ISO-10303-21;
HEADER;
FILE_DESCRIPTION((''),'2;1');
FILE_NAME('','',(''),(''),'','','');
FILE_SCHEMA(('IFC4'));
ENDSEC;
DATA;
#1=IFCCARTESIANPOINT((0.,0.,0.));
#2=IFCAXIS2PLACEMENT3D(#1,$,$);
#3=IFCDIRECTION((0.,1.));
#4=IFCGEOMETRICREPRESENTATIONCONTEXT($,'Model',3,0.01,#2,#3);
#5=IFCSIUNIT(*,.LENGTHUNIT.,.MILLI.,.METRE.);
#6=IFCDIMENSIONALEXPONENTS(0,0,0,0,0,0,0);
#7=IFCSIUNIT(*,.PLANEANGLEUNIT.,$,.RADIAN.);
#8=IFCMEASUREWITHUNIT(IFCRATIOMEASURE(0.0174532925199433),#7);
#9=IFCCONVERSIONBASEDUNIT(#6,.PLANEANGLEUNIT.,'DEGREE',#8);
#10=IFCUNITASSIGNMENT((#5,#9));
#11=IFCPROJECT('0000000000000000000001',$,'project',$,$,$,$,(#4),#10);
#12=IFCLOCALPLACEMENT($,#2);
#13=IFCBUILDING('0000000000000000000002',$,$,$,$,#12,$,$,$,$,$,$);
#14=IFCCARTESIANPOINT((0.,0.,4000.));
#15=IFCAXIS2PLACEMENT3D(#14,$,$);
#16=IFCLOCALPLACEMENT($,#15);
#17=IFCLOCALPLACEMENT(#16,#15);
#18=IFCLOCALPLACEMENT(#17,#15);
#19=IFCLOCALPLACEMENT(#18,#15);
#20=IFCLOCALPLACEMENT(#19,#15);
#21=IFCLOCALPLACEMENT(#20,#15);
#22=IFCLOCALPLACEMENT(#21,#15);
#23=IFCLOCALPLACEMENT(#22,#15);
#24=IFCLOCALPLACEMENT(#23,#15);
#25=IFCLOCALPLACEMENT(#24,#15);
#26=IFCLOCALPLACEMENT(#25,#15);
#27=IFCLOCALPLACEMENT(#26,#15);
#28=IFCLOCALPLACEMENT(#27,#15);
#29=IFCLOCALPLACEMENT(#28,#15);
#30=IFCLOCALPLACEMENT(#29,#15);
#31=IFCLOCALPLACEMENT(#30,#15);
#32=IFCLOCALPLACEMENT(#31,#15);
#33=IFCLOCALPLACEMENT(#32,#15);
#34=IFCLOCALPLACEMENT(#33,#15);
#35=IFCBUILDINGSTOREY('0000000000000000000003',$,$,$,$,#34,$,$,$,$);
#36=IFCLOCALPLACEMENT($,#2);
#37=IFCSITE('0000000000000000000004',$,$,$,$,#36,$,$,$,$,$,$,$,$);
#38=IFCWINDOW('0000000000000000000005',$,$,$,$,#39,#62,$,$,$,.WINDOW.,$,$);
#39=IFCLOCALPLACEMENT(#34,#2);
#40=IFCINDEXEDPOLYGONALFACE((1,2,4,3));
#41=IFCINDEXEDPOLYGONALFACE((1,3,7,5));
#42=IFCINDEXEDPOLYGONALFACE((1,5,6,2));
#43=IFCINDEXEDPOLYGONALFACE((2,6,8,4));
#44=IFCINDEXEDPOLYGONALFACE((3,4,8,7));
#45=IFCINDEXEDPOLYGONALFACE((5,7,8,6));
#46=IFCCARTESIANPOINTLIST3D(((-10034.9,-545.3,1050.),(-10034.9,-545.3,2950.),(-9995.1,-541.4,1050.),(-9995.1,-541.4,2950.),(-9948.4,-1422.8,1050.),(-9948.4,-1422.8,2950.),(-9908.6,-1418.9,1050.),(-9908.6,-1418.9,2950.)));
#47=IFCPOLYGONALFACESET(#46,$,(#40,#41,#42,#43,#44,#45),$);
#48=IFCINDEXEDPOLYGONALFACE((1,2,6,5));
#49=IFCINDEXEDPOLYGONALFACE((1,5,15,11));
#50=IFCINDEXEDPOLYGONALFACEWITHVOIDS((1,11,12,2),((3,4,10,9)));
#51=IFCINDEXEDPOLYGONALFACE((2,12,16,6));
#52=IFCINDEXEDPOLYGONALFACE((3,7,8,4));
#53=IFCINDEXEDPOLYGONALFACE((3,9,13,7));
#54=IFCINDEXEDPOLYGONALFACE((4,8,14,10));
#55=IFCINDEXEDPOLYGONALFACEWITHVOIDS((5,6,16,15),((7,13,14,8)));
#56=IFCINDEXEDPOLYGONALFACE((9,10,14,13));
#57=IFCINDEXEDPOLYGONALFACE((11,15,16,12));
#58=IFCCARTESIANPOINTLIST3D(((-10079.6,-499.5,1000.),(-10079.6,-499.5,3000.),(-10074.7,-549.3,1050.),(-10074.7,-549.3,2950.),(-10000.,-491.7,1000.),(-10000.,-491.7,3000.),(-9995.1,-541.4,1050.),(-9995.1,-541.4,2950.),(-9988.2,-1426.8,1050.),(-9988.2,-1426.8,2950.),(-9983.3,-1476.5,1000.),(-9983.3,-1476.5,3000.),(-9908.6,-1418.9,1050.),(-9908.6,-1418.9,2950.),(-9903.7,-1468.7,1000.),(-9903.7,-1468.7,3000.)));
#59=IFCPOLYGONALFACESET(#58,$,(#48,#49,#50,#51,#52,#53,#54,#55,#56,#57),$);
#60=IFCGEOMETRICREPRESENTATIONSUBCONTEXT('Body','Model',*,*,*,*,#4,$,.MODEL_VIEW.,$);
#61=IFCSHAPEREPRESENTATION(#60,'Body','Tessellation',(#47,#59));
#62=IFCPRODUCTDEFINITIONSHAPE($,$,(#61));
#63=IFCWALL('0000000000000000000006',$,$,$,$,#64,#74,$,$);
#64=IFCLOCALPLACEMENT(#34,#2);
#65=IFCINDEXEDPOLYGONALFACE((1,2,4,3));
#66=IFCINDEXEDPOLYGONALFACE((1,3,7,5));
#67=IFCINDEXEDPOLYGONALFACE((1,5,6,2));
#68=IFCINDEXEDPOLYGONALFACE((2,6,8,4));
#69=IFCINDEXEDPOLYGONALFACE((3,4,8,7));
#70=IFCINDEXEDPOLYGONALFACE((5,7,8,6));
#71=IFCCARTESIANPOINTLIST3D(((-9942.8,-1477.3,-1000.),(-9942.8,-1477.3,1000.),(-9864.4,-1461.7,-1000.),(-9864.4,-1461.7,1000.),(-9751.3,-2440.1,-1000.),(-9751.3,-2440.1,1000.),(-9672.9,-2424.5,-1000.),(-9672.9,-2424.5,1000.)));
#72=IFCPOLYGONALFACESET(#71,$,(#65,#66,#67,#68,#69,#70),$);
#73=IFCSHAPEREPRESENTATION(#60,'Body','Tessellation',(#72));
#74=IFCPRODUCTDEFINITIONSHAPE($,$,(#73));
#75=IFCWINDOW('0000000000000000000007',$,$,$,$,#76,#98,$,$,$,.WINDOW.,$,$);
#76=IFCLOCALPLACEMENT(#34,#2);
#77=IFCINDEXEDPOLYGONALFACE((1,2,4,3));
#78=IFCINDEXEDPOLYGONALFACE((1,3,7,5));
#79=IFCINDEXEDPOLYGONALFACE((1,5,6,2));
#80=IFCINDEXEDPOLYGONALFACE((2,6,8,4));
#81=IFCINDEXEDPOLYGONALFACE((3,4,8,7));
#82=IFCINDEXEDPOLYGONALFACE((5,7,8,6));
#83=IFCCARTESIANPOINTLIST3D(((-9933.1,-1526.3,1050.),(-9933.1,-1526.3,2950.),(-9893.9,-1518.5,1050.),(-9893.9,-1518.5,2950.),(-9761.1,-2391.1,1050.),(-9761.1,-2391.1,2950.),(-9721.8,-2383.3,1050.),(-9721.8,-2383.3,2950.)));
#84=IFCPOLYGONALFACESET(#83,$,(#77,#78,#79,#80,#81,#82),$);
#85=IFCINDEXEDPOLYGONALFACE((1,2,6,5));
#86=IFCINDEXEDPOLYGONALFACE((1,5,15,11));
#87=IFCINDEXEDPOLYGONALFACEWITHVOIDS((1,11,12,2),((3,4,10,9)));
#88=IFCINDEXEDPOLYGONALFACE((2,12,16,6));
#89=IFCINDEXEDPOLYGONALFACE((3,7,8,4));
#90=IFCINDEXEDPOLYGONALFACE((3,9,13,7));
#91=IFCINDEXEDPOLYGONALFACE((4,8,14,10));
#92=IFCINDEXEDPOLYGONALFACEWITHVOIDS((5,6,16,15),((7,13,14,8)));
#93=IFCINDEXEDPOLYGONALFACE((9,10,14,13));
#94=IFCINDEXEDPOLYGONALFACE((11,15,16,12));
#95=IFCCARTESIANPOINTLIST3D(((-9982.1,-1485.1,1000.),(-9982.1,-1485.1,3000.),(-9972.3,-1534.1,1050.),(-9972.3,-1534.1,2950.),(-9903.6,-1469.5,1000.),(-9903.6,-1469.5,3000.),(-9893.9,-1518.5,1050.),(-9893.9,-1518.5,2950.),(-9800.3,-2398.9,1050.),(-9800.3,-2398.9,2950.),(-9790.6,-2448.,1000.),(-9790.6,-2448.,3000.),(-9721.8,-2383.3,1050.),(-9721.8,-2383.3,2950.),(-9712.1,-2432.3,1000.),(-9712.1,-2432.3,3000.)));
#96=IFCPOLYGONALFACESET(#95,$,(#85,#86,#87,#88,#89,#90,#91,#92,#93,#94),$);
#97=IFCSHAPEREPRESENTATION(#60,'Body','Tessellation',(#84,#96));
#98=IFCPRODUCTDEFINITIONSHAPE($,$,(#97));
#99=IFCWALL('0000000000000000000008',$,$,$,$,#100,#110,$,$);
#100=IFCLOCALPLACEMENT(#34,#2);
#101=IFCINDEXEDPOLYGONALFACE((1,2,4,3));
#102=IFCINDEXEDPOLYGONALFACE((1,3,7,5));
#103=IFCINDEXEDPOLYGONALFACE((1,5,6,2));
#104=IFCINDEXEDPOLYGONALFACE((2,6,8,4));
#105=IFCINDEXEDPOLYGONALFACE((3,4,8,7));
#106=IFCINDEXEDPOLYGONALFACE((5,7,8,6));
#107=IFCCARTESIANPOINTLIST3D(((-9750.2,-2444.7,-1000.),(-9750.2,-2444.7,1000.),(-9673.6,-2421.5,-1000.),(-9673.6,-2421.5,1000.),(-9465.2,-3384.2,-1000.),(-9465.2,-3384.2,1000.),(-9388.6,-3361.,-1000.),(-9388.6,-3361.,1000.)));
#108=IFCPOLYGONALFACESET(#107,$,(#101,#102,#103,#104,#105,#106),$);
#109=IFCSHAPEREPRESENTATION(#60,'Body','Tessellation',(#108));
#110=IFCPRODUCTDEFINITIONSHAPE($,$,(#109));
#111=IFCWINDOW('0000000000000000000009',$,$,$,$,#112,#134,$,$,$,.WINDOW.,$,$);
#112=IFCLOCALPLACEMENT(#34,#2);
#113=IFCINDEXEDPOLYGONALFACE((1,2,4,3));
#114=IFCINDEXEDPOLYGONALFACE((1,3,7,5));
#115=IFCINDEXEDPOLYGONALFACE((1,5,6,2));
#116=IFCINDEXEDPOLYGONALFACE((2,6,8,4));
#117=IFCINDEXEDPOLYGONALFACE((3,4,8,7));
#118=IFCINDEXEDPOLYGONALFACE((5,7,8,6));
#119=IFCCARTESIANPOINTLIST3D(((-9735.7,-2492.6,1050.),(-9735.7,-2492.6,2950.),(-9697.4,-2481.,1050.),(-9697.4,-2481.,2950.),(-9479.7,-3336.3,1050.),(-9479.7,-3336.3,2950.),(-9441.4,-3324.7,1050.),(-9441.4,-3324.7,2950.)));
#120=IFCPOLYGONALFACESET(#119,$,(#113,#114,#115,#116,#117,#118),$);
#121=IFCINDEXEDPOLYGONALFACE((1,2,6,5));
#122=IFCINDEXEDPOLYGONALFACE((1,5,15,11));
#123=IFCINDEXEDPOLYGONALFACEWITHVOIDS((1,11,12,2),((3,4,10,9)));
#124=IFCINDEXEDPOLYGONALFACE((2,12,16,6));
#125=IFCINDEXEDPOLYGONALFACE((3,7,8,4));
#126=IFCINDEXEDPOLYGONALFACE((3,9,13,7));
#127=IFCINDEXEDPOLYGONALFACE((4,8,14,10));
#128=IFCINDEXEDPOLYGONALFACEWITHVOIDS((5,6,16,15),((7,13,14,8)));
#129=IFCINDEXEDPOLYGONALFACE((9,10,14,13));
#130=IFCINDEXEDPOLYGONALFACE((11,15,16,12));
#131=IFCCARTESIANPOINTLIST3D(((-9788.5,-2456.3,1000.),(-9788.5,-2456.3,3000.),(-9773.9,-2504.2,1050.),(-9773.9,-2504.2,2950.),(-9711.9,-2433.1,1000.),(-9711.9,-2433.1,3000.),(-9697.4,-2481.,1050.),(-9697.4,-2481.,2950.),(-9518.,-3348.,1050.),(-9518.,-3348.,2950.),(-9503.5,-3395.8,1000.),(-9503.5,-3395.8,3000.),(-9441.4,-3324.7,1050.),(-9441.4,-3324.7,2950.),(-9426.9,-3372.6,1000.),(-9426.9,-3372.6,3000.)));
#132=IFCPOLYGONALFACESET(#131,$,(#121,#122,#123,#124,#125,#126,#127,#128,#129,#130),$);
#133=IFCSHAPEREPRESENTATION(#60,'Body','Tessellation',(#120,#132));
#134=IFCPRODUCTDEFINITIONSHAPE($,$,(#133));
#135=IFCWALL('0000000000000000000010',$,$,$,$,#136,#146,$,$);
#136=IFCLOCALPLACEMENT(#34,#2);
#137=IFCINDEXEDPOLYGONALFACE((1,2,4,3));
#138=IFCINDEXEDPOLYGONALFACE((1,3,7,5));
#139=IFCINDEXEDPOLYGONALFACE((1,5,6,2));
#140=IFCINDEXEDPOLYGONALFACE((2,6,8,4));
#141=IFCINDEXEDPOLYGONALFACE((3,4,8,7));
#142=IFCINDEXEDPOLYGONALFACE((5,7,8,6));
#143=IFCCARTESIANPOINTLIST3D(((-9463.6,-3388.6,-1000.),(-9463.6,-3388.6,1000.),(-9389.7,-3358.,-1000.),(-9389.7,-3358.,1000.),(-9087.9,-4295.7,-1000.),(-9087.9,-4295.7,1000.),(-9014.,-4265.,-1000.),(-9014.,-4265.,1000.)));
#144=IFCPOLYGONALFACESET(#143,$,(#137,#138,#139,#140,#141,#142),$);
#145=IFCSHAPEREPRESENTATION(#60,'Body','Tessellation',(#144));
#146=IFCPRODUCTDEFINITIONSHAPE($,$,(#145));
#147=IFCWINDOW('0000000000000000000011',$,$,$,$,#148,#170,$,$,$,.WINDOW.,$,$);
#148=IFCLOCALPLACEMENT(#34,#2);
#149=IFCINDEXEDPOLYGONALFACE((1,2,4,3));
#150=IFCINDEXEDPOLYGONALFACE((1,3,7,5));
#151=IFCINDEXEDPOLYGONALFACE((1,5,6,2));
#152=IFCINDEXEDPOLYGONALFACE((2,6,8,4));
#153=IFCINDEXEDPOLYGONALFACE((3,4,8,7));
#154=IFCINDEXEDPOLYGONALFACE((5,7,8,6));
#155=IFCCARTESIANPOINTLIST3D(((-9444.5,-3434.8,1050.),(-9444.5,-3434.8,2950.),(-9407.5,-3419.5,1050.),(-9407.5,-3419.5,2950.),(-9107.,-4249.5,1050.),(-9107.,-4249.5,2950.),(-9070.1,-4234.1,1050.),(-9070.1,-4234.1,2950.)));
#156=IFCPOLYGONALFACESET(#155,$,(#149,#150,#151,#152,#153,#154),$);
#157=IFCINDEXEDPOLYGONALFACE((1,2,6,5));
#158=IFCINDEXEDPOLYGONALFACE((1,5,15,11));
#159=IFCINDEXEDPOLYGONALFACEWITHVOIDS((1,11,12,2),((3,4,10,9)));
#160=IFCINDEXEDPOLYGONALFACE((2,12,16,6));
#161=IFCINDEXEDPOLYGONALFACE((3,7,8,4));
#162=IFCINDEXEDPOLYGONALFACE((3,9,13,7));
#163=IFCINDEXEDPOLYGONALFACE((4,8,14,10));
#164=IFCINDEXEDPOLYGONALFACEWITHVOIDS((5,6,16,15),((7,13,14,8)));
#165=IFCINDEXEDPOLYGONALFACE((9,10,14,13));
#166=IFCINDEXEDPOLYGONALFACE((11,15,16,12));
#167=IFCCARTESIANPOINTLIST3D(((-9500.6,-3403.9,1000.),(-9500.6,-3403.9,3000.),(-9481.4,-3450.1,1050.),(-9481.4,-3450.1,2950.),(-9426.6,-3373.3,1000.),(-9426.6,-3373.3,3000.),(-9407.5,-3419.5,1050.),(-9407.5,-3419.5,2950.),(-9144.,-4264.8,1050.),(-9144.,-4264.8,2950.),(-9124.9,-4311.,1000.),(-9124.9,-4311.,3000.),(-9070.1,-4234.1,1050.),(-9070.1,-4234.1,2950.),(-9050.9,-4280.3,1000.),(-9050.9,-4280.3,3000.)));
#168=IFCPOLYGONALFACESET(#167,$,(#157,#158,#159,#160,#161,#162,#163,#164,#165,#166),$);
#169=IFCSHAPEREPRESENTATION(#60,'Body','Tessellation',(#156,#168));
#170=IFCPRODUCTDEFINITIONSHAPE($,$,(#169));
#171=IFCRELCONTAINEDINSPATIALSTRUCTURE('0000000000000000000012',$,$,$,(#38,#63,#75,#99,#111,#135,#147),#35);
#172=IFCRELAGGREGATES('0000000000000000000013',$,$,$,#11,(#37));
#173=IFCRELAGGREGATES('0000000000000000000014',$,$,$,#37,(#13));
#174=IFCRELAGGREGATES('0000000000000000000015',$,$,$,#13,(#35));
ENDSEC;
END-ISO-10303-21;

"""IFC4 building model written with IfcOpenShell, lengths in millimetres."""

from ifc_helpers import new_model, entity, si_unit, converted_unit, direction, frame, origin, origin_2d, place, context, subcontext, project, spatial, rectangle, extrude, element, save


model = new_model("IFC4")

# Units and contexts
model_context = context("Model", 3, precision=0.01, world=origin(), true_north=direction((0.0, 1.0)))
body_context = subcontext(model_context, "Body", "Model", "MODEL_VIEW")
ifc_project = project(units=[si_unit("LENGTHUNIT", "METRE", prefix="MILLI"), converted_unit("PLANEANGLEUNIT", "DEGREE", entity("IfcRatioMeasure", 0.0174532925199433), si_unit("PLANEANGLEUNIT", "RADIAN"), dimensions=[0, 0, 0, 0, 0, 0, 0])], contexts=[model_context])

# Site, building, storey
site_placement = place(None, origin())
site = spatial("IfcSite", under=ifc_project, at=site_placement)
building_placement = place(None, origin())
building = spatial("IfcBuilding", under=site, at=building_placement)
placement_1 = place(None, frame((0.0, 0.0, 4000.0)))
placement_2 = place(placement_1, frame((0.0, 0.0, 4000.0)))
placement_3 = place(placement_2, frame((0.0, 0.0, 4000.0)))
placement_4 = place(placement_3, frame((0.0, 0.0, 4000.0)))
placement_5 = place(placement_4, frame((0.0, 0.0, 4000.0)))
placement_6 = place(placement_5, frame((0.0, 0.0, 4000.0)))
placement_7 = place(placement_6, frame((0.0, 0.0, 4000.0)))
placement_8 = place(placement_7, frame((0.0, 0.0, 4000.0)))
placement_9 = place(placement_8, frame((0.0, 0.0, 4000.0)))
placement_10 = place(placement_9, frame((0.0, 0.0, 4000.0)))
placement_11 = place(placement_10, frame((0.0, 0.0, 4000.0)))
placement_12 = place(placement_11, frame((0.0, 0.0, 4000.0)))
placement_13 = place(placement_12, frame((0.0, 0.0, 4000.0)))
placement_14 = place(placement_13, frame((0.0, 0.0, 4000.0)))
placement_15 = place(placement_14, frame((0.0, 0.0, 4000.0)))
placement_16 = place(placement_15, frame((0.0, 0.0, 4000.0)))
placement_17 = place(placement_16, frame((0.0, 0.0, 4000.0)))
placement_18 = place(placement_17, frame((0.0, 0.0, 4000.0)))
storey_placement = place(placement_18, frame((0.0, 0.0, 4000.0)))
storey = spatial("IfcBuildingStorey", under=building, at=storey_placement)

# Shared definitions
cartesian_point_1 = entity("IfcCartesianPoint", [-440.9, -950.0])
shared_polyline = entity("IfcPolyline", [cartesian_point_1, entity("IfcCartesianPoint", [-440.9, 950.0]), entity("IfcCartesianPoint", [-440.9, 950.0]), entity("IfcCartesianPoint", [440.9, 950.0]), entity("IfcCartesianPoint", [440.9, 950.0]), entity("IfcCartesianPoint", [440.9, -950.0]), entity("IfcCartesianPoint", [440.9, -950.0]), entity("IfcCartesianPoint", [-440.9, -950.0]), cartesian_point_1])

# Window
window_1_placement = place(storey_placement, frame((-9951.8, -980.2, 2000.0), z_axis=(0.0, 0.0, 1.0), x_axis=(980.170299, -9951.847376, 0.0)))
cartesian_point_2 = entity("IfcCartesianPoint", [-490.9, -1000.0])
element("IfcWindow", 1, at=window_1_placement, inside=storey, PredefinedType="WINDOW", context=body_context, shape_type="SweptSolid", body=[
    entity("IfcExtrudedAreaSolid", entity("IfcArbitraryClosedProfileDef", "AREA", None, shared_polyline), entity("IfcAxis2Placement3D", entity("IfcCartesianPoint", [0.0, 0.0, 0.0]), entity("IfcDirection", [0.0, -1.0, 0.0]), entity("IfcDirection", [1.0, 0.0, 0.0])), entity("IfcDirection", [0.0, 0.0, 1.0]), 40.0),
    entity("IfcExtrudedAreaSolid", entity("IfcArbitraryProfileDefWithVoids", "AREA", None, entity("IfcPolyline", [cartesian_point_2, entity("IfcCartesianPoint", [-490.9, 1000.0]), entity("IfcCartesianPoint", [-490.9, 1000.0]), entity("IfcCartesianPoint", [490.9, 1000.0]), entity("IfcCartesianPoint", [490.9, 1000.0]), entity("IfcCartesianPoint", [490.9, -1000.0]), entity("IfcCartesianPoint", [490.9, -1000.0]), entity("IfcCartesianPoint", [-490.9, -1000.0]), cartesian_point_2]), [shared_polyline]), entity("IfcAxis2Placement3D", entity("IfcCartesianPoint", [0.0, 0.0, 0.0]), entity("IfcDirection", [0.0, -1.0, 0.0]), entity("IfcDirection", [1.0, 0.0, 0.0])), entity("IfcDirection", [0.0, 0.0, 1.0]), 80.0),
])

# Wall
wall_1_placement = place(storey_placement, frame((-9807.9, -1950.9, -1000.0), z_axis=(0.0, 0.0, 1.0), x_axis=(1950.902524, -9807.852943, 0.0)))
element("IfcWall", 2, at=wall_1_placement, inside=storey, context=body_context, shape_type="SweptSolid", body=[
    extrude(rectangle(XDim=981.7, YDim=80.0, at=origin_2d()), origin(), (0.0, 0.0, 1.0), 2000.0),
])

# Window
window_2_placement = place(storey_placement, frame((-9807.9, -1950.9, 2000.0), z_axis=(0.0, 0.0, 1.0), x_axis=(1950.902524, -9807.852943, 0.0)))
cartesian_point_3 = entity("IfcCartesianPoint", [-490.9, -1000.0])
element("IfcWindow", 3, at=window_2_placement, inside=storey, PredefinedType="WINDOW", context=body_context, shape_type="SweptSolid", body=[
    entity("IfcExtrudedAreaSolid", entity("IfcArbitraryClosedProfileDef", "AREA", None, shared_polyline), entity("IfcAxis2Placement3D", entity("IfcCartesianPoint", [0.0, 0.0, 0.0]), entity("IfcDirection", [0.0, -1.0, 0.0]), entity("IfcDirection", [1.0, 0.0, 0.0])), entity("IfcDirection", [0.0, 0.0, 1.0]), 40.0),
    entity("IfcExtrudedAreaSolid", entity("IfcArbitraryProfileDefWithVoids", "AREA", None, entity("IfcPolyline", [cartesian_point_3, entity("IfcCartesianPoint", [-490.9, 1000.0]), entity("IfcCartesianPoint", [-490.9, 1000.0]), entity("IfcCartesianPoint", [490.9, 1000.0]), entity("IfcCartesianPoint", [490.9, 1000.0]), entity("IfcCartesianPoint", [490.9, -1000.0]), entity("IfcCartesianPoint", [490.9, -1000.0]), entity("IfcCartesianPoint", [-490.9, -1000.0]), cartesian_point_3]), [shared_polyline]), entity("IfcAxis2Placement3D", entity("IfcCartesianPoint", [0.0, 0.0, 0.0]), entity("IfcDirection", [0.0, -1.0, 0.0]), entity("IfcDirection", [1.0, 0.0, 0.0])), entity("IfcDirection", [0.0, 0.0, 1.0]), 80.0),
])

# Wall
wall_2_placement = place(storey_placement, frame((-9569.4, -2902.8, -1000.0), z_axis=(0.0, 0.0, 1.0), x_axis=(2902.846475, -9569.403447, 0.0)))
element("IfcWall", 4, at=wall_2_placement, inside=storey, context=body_context, shape_type="SweptSolid", body=[
    extrude(rectangle(XDim=981.7, YDim=80.0, at=origin_2d()), origin(), (0.0, 0.0, 1.0), 2000.0),
])

# Window
window_3_placement = place(storey_placement, frame((-9569.4, -2902.8, 2000.0), z_axis=(0.0, 0.0, 1.0), x_axis=(2902.846475, -9569.403447, 0.0)))
cartesian_point_4 = entity("IfcCartesianPoint", [-490.9, -1000.0])
element("IfcWindow", 5, at=window_3_placement, inside=storey, PredefinedType="WINDOW", context=body_context, shape_type="SweptSolid", body=[
    entity("IfcExtrudedAreaSolid", entity("IfcArbitraryClosedProfileDef", "AREA", None, shared_polyline), entity("IfcAxis2Placement3D", entity("IfcCartesianPoint", [0.0, 0.0, 0.0]), entity("IfcDirection", [0.0, -1.0, 0.0]), entity("IfcDirection", [1.0, 0.0, 0.0])), entity("IfcDirection", [0.0, 0.0, 1.0]), 40.0),
    entity("IfcExtrudedAreaSolid", entity("IfcArbitraryProfileDefWithVoids", "AREA", None, entity("IfcPolyline", [cartesian_point_4, entity("IfcCartesianPoint", [-490.9, 1000.0]), entity("IfcCartesianPoint", [-490.9, 1000.0]), entity("IfcCartesianPoint", [490.9, 1000.0]), entity("IfcCartesianPoint", [490.9, 1000.0]), entity("IfcCartesianPoint", [490.9, -1000.0]), entity("IfcCartesianPoint", [490.9, -1000.0]), entity("IfcCartesianPoint", [-490.9, -1000.0]), cartesian_point_4]), [shared_polyline]), entity("IfcAxis2Placement3D", entity("IfcCartesianPoint", [0.0, 0.0, 0.0]), entity("IfcDirection", [0.0, -1.0, 0.0]), entity("IfcDirection", [1.0, 0.0, 0.0])), entity("IfcDirection", [0.0, 0.0, 1.0]), 80.0),
])

# Wall
wall_3_placement = place(storey_placement, frame((-9238.8, -3826.8, -1000.0), z_axis=(0.0, 0.0, 1.0), x_axis=(3826.834406, -9238.795291, 0.0)))
element("IfcWall", 6, at=wall_3_placement, inside=storey, context=body_context, shape_type="SweptSolid", body=[
    extrude(rectangle(XDim=981.7, YDim=80.0, at=origin_2d()), origin(), (0.0, 0.0, 1.0), 2000.0),
])

# Window
window_4_placement = place(storey_placement, frame((-9238.8, -3826.8, 2000.0), z_axis=(0.0, 0.0, 1.0), x_axis=(3826.834406, -9238.795291, 0.0)))
cartesian_point_5 = entity("IfcCartesianPoint", [-490.9, -1000.0])
element("IfcWindow", 7, at=window_4_placement, inside=storey, PredefinedType="WINDOW", context=body_context, shape_type="SweptSolid", body=[
    entity("IfcExtrudedAreaSolid", entity("IfcArbitraryClosedProfileDef", "AREA", None, shared_polyline), entity("IfcAxis2Placement3D", entity("IfcCartesianPoint", [0.0, 0.0, 0.0]), entity("IfcDirection", [0.0, -1.0, 0.0]), entity("IfcDirection", [1.0, 0.0, 0.0])), entity("IfcDirection", [0.0, 0.0, 1.0]), 40.0),
    entity("IfcExtrudedAreaSolid", entity("IfcArbitraryProfileDefWithVoids", "AREA", None, entity("IfcPolyline", [cartesian_point_5, entity("IfcCartesianPoint", [-490.9, 1000.0]), entity("IfcCartesianPoint", [-490.9, 1000.0]), entity("IfcCartesianPoint", [490.9, 1000.0]), entity("IfcCartesianPoint", [490.9, 1000.0]), entity("IfcCartesianPoint", [490.9, -1000.0]), entity("IfcCartesianPoint", [490.9, -1000.0]), entity("IfcCartesianPoint", [-490.9, -1000.0]), cartesian_point_5]), [shared_polyline]), entity("IfcAxis2Placement3D", entity("IfcCartesianPoint", [0.0, 0.0, 0.0]), entity("IfcDirection", [0.0, -1.0, 0.0]), entity("IfcDirection", [1.0, 0.0, 0.0])), entity("IfcDirection", [0.0, 0.0, 1.0]), 80.0),
])

save(model, "model.ifc")
